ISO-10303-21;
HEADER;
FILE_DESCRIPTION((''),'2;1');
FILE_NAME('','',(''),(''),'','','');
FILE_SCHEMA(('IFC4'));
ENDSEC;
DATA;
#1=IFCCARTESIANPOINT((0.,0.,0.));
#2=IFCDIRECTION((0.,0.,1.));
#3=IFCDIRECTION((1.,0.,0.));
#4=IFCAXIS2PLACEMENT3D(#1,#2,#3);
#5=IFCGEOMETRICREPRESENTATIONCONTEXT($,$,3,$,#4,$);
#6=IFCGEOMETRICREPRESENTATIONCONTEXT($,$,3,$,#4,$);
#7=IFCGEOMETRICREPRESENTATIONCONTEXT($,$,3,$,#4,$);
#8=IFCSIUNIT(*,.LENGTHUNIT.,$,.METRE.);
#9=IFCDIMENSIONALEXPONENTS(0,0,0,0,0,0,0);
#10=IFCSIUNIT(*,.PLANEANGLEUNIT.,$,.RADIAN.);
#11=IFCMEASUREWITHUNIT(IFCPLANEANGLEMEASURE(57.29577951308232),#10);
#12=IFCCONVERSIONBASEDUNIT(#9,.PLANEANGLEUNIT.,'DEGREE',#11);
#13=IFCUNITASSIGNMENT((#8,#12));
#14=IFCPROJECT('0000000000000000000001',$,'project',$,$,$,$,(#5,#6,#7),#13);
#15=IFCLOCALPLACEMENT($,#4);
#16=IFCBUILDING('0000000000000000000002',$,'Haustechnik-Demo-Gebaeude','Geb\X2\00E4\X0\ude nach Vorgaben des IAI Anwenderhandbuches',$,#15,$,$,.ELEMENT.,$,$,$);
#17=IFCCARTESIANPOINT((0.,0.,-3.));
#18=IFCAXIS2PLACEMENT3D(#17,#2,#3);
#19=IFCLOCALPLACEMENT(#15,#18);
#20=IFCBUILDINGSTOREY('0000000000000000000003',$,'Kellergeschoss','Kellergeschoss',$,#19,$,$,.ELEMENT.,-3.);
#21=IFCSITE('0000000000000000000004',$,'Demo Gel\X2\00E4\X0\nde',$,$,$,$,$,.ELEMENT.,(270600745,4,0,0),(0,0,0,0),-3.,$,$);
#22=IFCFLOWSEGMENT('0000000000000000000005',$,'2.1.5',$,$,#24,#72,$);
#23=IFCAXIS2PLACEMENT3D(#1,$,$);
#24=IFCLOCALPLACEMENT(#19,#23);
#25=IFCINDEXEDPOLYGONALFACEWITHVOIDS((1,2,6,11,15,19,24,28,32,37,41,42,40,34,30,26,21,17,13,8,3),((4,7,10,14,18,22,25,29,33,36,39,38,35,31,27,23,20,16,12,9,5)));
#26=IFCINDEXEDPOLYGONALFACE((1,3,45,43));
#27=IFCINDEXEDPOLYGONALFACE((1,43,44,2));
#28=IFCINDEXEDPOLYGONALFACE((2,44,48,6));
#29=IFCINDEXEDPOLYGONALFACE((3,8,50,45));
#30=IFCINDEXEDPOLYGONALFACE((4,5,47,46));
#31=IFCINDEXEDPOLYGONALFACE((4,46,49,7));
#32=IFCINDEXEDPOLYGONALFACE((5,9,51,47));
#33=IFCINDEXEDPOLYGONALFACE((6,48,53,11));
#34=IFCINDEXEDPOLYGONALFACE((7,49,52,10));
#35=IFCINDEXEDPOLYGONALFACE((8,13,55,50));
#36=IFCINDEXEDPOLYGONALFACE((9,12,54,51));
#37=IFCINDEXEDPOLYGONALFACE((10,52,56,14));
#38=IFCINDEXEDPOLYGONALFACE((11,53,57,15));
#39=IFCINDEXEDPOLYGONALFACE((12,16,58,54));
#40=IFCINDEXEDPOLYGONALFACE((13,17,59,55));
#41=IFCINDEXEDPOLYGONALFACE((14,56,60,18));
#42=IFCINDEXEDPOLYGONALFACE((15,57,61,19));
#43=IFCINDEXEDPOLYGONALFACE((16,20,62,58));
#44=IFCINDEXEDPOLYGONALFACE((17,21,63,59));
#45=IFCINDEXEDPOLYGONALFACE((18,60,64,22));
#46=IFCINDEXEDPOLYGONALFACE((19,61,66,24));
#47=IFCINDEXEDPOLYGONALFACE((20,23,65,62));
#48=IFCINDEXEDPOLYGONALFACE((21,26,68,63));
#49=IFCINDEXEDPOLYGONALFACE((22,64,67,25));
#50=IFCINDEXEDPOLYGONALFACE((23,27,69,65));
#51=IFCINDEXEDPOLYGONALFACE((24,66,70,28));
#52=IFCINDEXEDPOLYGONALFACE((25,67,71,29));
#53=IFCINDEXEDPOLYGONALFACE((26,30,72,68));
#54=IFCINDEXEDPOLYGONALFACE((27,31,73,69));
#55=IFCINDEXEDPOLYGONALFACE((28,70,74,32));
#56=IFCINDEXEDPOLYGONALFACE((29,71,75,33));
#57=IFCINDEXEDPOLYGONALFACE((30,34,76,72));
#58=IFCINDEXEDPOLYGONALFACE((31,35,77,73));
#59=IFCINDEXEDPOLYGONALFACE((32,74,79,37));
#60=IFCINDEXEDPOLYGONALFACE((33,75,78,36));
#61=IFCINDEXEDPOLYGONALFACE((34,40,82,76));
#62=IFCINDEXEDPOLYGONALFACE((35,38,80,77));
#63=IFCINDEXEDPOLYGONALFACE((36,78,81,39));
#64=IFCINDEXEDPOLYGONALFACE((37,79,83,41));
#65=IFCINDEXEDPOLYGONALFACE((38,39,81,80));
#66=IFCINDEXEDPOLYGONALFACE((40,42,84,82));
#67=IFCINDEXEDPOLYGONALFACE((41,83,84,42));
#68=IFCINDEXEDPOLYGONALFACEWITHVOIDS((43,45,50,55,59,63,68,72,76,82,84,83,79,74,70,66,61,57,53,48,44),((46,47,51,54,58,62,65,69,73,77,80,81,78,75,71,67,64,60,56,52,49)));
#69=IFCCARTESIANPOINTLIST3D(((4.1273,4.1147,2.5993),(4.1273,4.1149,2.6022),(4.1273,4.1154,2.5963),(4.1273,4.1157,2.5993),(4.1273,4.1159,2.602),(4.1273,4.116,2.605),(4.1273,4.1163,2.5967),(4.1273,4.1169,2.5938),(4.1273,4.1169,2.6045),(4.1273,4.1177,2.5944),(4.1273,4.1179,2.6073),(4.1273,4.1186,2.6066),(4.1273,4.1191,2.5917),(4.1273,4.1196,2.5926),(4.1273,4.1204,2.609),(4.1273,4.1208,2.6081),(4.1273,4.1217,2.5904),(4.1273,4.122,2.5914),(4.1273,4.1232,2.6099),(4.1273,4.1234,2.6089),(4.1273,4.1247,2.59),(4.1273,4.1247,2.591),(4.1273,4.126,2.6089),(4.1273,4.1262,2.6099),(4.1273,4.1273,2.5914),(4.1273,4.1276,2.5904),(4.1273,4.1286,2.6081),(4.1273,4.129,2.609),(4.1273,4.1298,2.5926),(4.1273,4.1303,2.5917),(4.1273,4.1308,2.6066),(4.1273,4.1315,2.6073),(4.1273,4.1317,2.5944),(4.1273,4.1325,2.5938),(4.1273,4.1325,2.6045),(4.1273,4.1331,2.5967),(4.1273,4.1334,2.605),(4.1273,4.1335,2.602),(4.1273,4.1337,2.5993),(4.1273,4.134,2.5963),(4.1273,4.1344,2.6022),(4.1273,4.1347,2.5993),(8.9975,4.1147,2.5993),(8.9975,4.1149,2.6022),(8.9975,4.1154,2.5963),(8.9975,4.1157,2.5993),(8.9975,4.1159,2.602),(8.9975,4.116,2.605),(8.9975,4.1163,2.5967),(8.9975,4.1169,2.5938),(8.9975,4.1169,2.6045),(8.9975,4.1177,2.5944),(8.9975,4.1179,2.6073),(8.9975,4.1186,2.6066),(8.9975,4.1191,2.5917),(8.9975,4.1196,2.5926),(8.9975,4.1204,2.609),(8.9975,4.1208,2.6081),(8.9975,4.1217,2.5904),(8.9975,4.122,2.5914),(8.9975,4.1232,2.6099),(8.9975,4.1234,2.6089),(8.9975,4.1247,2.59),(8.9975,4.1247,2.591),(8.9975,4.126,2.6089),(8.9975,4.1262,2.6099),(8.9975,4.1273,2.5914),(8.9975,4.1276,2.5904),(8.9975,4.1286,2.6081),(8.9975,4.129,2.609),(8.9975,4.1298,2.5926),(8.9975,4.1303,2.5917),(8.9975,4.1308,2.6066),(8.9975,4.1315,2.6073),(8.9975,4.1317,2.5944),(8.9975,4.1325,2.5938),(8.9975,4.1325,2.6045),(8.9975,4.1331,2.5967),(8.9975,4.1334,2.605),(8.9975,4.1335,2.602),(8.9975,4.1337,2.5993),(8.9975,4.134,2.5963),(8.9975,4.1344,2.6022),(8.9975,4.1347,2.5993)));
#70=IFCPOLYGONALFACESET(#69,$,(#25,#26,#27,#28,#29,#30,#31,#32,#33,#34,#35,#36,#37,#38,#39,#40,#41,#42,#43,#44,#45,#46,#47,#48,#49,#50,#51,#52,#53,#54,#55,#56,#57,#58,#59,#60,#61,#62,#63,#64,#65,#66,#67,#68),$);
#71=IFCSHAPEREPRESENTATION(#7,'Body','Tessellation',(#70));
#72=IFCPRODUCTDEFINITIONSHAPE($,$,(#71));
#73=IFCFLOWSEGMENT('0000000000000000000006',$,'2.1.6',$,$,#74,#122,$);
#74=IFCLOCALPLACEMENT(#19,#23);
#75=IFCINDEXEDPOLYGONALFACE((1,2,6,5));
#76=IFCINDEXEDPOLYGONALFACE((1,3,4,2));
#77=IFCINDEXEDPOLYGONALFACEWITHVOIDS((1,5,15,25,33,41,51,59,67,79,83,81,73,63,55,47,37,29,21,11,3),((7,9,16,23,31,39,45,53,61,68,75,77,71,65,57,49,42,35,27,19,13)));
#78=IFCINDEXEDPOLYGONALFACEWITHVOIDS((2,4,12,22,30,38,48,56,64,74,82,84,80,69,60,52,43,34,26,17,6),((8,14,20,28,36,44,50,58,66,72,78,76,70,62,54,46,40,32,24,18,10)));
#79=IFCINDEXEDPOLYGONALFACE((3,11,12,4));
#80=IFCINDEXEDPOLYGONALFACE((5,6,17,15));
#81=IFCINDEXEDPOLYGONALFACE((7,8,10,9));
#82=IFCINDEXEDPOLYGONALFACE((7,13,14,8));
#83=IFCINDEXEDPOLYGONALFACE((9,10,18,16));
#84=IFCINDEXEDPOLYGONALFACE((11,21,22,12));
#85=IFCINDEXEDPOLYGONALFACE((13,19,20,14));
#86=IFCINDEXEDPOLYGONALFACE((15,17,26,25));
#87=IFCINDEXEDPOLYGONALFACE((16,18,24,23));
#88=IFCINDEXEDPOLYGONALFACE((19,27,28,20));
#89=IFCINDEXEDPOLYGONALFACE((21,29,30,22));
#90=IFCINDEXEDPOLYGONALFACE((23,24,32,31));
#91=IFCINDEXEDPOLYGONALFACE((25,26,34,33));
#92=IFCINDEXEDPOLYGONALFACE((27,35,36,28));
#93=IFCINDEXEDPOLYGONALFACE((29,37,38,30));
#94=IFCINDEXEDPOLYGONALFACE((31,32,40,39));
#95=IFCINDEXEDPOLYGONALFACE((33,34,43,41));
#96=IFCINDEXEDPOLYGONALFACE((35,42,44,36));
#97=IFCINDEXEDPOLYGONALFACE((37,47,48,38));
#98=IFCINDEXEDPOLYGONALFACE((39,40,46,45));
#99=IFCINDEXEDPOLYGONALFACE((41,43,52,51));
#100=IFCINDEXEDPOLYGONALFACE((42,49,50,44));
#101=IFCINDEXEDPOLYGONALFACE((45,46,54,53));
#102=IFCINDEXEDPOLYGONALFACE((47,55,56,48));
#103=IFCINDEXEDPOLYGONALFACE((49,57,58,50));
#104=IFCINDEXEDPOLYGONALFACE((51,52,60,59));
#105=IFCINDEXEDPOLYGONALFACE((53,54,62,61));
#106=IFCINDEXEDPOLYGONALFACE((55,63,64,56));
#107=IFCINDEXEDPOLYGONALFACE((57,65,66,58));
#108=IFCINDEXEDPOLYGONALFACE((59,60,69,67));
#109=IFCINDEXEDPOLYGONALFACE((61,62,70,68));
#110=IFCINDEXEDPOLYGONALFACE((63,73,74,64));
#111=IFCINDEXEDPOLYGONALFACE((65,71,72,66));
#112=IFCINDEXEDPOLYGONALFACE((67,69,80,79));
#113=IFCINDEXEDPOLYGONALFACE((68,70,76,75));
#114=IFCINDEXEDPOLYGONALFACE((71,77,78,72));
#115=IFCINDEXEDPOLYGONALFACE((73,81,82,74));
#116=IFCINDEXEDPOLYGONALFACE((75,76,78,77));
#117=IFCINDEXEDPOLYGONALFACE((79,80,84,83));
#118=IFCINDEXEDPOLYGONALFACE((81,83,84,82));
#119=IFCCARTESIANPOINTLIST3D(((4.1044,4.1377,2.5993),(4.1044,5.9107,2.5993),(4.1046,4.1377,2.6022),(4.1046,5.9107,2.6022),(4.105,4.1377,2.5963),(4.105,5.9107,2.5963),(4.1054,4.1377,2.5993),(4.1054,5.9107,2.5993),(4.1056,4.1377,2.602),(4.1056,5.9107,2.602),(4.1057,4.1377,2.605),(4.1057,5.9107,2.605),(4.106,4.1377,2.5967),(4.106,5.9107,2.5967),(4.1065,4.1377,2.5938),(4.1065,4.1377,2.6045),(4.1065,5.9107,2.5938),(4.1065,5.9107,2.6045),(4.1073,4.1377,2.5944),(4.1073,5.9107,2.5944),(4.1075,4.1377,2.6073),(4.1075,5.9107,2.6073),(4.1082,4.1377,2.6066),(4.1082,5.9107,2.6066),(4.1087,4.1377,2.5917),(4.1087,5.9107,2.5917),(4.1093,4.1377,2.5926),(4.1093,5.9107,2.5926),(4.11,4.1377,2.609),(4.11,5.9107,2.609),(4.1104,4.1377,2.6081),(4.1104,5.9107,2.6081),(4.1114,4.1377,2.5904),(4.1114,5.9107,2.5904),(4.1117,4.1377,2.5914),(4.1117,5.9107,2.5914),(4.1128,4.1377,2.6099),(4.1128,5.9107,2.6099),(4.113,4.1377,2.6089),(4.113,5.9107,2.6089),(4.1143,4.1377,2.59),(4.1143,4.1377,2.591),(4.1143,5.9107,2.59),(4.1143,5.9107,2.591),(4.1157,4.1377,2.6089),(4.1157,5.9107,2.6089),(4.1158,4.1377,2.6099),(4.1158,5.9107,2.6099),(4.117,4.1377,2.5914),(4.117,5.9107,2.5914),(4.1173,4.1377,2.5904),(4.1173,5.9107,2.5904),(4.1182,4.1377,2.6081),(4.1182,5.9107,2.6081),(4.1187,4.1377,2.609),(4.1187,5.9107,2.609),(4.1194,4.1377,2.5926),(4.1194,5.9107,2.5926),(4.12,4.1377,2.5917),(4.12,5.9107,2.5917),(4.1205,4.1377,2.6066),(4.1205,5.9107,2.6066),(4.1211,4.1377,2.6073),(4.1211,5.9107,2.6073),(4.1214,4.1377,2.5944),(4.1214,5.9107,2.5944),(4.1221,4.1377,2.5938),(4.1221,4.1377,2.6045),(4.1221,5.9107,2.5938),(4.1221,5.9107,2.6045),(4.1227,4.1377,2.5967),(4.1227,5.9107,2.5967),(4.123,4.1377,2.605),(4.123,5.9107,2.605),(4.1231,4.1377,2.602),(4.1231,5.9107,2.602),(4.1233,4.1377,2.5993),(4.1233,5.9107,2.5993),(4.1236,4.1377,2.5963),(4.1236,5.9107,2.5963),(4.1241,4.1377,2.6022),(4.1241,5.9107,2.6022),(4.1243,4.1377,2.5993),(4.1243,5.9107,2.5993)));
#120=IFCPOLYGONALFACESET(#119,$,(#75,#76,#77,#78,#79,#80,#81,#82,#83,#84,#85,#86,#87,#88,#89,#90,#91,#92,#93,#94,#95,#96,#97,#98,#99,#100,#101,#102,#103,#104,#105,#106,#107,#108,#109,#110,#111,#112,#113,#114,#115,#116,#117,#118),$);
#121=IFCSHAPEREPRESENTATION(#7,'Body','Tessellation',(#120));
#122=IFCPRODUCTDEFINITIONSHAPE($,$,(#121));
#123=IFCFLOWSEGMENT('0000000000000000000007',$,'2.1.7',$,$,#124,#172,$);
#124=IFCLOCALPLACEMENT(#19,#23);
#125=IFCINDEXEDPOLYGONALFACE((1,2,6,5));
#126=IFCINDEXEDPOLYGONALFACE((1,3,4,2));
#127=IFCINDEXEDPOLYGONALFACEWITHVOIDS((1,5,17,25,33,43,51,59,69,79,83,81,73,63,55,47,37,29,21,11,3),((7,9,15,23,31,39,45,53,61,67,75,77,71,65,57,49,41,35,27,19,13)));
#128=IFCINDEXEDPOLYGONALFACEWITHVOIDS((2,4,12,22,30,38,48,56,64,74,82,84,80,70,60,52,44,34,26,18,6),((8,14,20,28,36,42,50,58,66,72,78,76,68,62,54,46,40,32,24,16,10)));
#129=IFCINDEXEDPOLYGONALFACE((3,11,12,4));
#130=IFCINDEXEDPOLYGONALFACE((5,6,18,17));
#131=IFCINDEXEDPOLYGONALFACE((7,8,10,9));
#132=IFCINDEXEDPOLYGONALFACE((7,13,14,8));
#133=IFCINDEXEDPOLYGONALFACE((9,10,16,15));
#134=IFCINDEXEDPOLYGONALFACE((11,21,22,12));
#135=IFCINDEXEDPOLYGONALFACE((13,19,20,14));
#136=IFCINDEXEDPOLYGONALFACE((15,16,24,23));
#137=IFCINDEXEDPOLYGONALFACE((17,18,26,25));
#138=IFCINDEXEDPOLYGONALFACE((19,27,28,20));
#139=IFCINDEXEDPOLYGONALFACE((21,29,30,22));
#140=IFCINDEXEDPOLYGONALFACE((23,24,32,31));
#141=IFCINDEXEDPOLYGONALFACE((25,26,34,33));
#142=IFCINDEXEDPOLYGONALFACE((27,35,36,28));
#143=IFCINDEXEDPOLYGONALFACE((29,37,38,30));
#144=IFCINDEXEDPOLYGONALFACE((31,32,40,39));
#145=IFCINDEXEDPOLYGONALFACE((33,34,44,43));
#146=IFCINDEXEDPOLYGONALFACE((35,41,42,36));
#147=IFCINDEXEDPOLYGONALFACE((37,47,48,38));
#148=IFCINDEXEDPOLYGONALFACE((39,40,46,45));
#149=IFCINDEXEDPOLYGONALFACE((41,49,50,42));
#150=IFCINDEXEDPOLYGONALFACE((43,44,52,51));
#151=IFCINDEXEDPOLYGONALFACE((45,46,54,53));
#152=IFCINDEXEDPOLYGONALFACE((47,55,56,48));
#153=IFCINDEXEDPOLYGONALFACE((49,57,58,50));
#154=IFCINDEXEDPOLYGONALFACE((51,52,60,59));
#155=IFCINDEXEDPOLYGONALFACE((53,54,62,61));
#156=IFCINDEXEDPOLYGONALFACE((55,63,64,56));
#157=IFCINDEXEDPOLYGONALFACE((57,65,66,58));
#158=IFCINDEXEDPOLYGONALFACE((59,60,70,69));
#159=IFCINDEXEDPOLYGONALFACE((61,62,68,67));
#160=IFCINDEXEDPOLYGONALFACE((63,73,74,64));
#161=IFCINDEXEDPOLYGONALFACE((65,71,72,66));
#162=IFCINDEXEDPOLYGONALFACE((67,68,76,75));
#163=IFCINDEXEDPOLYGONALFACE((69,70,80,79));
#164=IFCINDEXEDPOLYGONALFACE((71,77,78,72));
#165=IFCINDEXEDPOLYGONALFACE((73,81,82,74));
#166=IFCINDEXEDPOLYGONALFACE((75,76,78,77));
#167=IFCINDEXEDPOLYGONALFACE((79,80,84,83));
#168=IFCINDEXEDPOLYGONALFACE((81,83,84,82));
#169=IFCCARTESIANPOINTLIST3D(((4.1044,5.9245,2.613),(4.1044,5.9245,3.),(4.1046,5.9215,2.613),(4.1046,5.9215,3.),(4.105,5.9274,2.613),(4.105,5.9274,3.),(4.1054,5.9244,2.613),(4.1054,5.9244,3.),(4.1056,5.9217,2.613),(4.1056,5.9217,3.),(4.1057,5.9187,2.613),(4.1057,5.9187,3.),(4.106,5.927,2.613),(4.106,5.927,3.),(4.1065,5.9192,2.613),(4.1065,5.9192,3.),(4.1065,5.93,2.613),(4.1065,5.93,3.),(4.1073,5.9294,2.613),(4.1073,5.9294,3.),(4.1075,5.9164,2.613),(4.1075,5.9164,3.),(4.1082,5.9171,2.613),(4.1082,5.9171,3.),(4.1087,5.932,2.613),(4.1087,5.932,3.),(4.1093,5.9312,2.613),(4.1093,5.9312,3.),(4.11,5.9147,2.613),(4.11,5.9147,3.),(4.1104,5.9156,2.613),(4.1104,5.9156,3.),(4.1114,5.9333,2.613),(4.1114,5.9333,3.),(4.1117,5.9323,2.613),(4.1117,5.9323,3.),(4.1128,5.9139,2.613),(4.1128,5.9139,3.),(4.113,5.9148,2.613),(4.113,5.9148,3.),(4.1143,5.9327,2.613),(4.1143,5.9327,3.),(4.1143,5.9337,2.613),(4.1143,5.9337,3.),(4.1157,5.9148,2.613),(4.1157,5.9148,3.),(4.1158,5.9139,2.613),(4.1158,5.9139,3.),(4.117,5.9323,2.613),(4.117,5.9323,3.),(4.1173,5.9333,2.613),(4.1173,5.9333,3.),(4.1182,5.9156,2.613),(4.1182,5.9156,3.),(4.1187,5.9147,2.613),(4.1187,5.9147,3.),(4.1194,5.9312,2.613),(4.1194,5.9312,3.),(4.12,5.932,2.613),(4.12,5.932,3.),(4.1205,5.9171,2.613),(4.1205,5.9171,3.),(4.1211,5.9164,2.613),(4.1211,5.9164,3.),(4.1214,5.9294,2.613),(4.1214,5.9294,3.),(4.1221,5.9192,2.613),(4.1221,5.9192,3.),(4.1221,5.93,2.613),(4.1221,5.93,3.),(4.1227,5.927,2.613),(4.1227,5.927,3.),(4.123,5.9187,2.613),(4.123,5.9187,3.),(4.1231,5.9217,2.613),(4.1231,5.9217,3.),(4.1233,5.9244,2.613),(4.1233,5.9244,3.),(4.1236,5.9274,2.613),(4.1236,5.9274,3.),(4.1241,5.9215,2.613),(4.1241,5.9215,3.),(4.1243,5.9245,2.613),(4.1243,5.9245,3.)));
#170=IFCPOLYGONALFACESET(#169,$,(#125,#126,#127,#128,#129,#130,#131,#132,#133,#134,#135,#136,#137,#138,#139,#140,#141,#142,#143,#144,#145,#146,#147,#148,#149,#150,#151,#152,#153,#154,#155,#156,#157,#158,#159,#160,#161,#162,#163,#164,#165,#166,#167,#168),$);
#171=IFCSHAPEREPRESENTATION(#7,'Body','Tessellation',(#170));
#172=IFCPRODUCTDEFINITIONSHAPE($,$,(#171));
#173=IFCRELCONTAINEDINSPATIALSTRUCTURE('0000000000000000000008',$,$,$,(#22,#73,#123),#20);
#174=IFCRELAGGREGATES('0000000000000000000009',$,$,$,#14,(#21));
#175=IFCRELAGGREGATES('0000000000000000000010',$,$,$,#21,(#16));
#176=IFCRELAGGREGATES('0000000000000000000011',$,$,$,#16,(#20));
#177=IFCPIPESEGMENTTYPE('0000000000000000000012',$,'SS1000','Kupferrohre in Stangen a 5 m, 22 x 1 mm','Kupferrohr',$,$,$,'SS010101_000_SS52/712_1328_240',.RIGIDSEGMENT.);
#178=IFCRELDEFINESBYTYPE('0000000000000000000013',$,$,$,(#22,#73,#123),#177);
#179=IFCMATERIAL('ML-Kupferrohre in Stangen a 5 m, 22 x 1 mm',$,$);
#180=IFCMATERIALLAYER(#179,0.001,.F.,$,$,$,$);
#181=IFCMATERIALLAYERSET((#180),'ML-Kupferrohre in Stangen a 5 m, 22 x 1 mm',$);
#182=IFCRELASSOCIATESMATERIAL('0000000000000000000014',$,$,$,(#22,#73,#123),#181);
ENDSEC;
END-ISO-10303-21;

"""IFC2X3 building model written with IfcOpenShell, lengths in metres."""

from ifc_helpers import new_model, entity, si_unit, converted_unit, frame, origin_with_axes, origin_2d_with_axis, place, context, project, spatial, hollow_circle, extrude, material, layer, layer_set, layer_usage, type_object, element, save


model = new_model("IFC2X3")

# Units and contexts
context_of_model_1 = context(None, 3, world=origin_with_axes())
context_of_model_2 = context(None, 3, world=origin_with_axes())
context_of_model_3 = context(None, 3, world=origin_with_axes())
ifc_project = project(units=[si_unit("LENGTHUNIT", "METRE"), converted_unit("PLANEANGLEUNIT", "DEGREE", entity("IfcPlaneAngleMeasure", 57.29577951308232), si_unit("PLANEANGLEUNIT", "RADIAN"), dimensions=[0, 0, 0, 0, 0, 0, 0])], contexts=[context_of_model_1, context_of_model_2, context_of_model_3])

# Site, building, storey
site = spatial("IfcSite", under=ifc_project, Name="Demo Gelände", CompositionType="ELEMENT", RefLatitude=(270600745, 4, 0, 0), RefLongitude=(0, 0, 0, 0), RefElevation=-3.0)
building_placement = place(None, origin_with_axes())
building = spatial("IfcBuilding", under=site, at=building_placement, Name="Haustechnik-Demo-Gebaeude", Description="Gebäude nach Vorgaben des IAI Anwenderhandbuches", CompositionType="ELEMENT")
storey_placement = place(building_placement, frame((0.0, 0.0, -3.0), z_axis=(0.0, 0.0, 1.0), x_axis=(1.0, 0.0, 0.0)))
storey = spatial("IfcBuildingStorey", under=building, at=storey_placement, Name="Kellergeschoss", Description="Kellergeschoss", CompositionType="ELEMENT", Elevation=-3.0)

# Flow segments
ifc_material = material(Name="ML-Kupferrohre in Stangen a 5 m, 22 x 1 mm")
ifc_layer = layer(ifc_material, 0.001, ventilated=False)
ifc_layer_set = layer_set([ifc_layer], Name="ML-Kupferrohre in Stangen a 5 m, 22 x 1 mm")
ifc_layer_usage = layer_usage(ifc_layer_set, "AXIS2", "POSITIVE", 0.0)
pipe_segment_type_1 = type_object("IfcPipeSegmentType", Name="SS1000", Description="Kupferrohre in Stangen a 5 m, 22 x 1 mm", ApplicableOccurrence="Kupferrohr", ElementType="SS010101_000_SS52/712_1328_240", PredefinedType="RIGIDSEGMENT")
flow_segment_1_placement = place(storey_placement, frame((8.9975, 4.1247, 2.6), z_axis=(-1.0, 0.0, 0.0), x_axis=(0.0, 0.0, -1.0)))
element("IfcFlowSegment", 1, at=flow_segment_1_placement, inside=storey, type_object=pipe_segment_type_1, material=ifc_layer_usage, Name="2.1.5", context=context_of_model_3, shape_type="SweptSolid", body=[
    extrude(hollow_circle(Radius=0.01, WallThickness=0.001, at=origin_2d_with_axis()), origin_with_axes(), (0.0, 0.0, 1.0), 4.8702),
])
flow_segment_2_placement = place(storey_placement, frame((4.1143, 4.1377, 2.6), z_axis=(0.0, 1.0, 0.0), x_axis=(0.0, 0.0, -1.0)))
element("IfcFlowSegment", 2, at=flow_segment_2_placement, inside=storey, type_object=pipe_segment_type_1, material=ifc_layer_usage, Name="2.1.6", context=context_of_model_3, shape_type="SweptSolid", body=[
    extrude(hollow_circle(Radius=0.01, WallThickness=0.001, at=origin_2d_with_axis()), origin_with_axes(), (0.0, 0.0, 1.0), 1.773),
])
flow_segment_3_placement = place(storey_placement, frame((4.1143, 5.9237, 2.613), z_axis=(0.0, 0.0, 1.0), x_axis=(0.0, 1.0, 0.0)))
element("IfcFlowSegment", 3, at=flow_segment_3_placement, inside=storey, type_object=pipe_segment_type_1, material=ifc_layer_usage, Name="2.1.7", context=context_of_model_3, shape_type="SweptSolid", body=[
    extrude(hollow_circle(Radius=0.01, WallThickness=0.001, at=origin_2d_with_axis()), origin_with_axes(), (0.0, 0.0, 1.0), 0.387),
])

save(model, "model.ifc")
